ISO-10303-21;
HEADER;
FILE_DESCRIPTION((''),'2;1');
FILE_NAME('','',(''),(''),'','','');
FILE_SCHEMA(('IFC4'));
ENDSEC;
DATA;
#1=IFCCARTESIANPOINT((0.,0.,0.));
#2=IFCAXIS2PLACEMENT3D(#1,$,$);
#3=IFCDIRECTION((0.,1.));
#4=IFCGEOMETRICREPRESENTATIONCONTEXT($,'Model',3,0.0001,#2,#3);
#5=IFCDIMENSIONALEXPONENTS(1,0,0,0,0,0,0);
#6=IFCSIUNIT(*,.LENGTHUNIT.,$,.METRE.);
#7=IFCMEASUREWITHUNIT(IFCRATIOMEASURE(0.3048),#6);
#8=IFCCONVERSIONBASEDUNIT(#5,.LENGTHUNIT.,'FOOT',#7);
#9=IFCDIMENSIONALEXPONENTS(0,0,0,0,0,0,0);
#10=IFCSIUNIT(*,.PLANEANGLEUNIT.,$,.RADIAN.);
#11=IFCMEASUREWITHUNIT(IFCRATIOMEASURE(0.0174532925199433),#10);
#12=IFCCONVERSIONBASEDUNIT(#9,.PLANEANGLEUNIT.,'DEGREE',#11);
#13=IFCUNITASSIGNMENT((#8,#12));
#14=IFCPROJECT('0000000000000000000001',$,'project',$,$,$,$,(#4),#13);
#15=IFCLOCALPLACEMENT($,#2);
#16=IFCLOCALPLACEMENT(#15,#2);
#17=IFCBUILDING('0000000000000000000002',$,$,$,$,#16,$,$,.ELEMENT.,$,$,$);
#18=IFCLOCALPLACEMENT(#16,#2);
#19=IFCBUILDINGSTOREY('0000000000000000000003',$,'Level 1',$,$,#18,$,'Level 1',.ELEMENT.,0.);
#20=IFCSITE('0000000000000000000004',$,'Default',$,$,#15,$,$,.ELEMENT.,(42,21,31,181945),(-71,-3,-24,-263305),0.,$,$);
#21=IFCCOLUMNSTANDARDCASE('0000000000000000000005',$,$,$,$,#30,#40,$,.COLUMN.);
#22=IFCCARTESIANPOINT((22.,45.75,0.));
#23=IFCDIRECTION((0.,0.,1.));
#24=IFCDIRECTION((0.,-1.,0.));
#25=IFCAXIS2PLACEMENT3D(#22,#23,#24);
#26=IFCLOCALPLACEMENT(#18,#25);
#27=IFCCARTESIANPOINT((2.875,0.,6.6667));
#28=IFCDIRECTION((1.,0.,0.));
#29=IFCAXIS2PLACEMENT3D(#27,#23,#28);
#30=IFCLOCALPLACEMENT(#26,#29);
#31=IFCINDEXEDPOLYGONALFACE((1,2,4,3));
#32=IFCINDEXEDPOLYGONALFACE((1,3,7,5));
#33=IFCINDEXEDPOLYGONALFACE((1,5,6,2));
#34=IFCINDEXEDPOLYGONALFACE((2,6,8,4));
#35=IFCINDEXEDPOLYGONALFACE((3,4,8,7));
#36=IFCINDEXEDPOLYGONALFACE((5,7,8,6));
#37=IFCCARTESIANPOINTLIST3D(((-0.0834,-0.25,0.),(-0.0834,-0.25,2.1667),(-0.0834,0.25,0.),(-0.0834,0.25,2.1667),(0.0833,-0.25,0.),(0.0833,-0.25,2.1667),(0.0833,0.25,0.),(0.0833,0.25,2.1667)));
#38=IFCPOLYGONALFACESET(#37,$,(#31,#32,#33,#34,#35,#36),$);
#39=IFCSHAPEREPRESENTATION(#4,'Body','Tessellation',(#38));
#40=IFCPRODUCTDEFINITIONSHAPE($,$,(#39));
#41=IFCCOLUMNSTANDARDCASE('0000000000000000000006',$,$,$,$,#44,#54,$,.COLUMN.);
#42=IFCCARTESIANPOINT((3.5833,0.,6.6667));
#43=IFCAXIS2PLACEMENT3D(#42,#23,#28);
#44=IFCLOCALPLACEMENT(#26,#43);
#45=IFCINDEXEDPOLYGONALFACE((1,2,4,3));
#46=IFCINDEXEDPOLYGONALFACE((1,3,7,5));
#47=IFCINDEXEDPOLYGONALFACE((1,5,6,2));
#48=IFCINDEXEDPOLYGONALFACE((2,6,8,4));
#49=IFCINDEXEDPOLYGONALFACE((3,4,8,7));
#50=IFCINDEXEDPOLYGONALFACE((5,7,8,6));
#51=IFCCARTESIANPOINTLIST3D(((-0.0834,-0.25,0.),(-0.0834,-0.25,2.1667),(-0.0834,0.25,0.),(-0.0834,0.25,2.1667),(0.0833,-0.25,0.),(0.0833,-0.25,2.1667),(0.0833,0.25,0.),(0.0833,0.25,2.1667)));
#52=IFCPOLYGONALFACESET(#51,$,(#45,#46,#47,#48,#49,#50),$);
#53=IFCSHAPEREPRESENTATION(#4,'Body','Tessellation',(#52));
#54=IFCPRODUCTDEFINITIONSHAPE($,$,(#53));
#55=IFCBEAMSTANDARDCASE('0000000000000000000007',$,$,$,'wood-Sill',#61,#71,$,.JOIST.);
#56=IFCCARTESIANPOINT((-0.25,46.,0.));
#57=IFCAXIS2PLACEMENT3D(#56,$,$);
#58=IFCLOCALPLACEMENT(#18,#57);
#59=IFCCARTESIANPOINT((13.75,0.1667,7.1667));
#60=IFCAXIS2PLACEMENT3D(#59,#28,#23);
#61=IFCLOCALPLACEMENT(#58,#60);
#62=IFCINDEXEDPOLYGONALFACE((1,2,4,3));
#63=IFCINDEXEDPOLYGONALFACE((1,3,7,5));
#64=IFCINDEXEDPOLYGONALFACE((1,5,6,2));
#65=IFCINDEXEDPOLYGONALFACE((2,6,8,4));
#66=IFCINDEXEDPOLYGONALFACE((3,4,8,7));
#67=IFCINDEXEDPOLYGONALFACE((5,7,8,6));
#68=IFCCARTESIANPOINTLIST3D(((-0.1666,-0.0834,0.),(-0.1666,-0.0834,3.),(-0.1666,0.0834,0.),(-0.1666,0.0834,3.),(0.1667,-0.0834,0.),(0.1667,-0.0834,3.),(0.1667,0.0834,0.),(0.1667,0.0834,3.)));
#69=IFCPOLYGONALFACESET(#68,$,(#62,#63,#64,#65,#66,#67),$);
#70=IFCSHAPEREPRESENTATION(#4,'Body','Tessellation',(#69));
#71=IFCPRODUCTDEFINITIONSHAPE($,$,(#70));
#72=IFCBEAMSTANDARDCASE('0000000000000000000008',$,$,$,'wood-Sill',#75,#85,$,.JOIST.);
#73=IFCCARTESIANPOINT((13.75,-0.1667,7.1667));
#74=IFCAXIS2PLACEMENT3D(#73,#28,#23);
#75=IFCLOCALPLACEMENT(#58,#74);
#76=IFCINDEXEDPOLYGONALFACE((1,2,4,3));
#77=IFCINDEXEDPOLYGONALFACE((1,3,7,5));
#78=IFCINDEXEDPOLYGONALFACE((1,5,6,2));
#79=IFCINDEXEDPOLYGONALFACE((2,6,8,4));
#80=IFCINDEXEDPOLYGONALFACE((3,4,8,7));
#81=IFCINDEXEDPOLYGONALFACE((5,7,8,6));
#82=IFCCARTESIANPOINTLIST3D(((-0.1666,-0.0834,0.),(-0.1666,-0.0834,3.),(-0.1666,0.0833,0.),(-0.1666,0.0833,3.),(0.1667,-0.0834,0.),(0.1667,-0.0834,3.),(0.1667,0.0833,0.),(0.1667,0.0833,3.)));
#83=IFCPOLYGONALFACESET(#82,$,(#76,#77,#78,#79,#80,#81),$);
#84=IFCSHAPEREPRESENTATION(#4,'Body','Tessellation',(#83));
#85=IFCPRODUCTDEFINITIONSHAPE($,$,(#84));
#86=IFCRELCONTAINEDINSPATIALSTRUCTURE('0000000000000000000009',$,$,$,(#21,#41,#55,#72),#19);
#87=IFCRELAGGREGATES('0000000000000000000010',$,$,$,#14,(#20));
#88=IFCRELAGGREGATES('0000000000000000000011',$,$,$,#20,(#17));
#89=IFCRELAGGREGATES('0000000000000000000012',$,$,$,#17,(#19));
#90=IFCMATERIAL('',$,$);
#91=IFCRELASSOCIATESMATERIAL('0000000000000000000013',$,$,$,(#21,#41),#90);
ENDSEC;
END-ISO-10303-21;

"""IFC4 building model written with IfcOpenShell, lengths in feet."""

from ifc_helpers import new_model, entity, si_unit, converted_unit, direction, frame, origin, origin_with_axes, place, context, project, spatial, rectangle, extrude, material, element, save


model = new_model("IFC4")

# Units and contexts
model_context = context("Model", 3, precision=0.0001, world=origin(), true_north=direction((0.0, 1.0)))
ifc_project = project(units=[converted_unit("LENGTHUNIT", "FOOT", entity("IfcRatioMeasure", 0.3048), si_unit("LENGTHUNIT", "METRE"), dimensions=[1, 0, 0, 0, 0, 0, 0]), converted_unit("PLANEANGLEUNIT", "DEGREE", entity("IfcRatioMeasure", 0.0174532925199433), si_unit("PLANEANGLEUNIT", "RADIAN"), dimensions=[0, 0, 0, 0, 0, 0, 0])], contexts=[model_context])

# Site, building, storey
site_placement = place(None, origin())
site = spatial("IfcSite", under=ifc_project, at=site_placement, Name="Default", CompositionType="ELEMENT", RefLatitude=(42, 21, 31, 181945), RefLongitude=(-71, -3, -24, -263305), RefElevation=0.0)
building_placement = place(site_placement, origin())
building = spatial("IfcBuilding", under=site, at=building_placement, CompositionType="ELEMENT")
storey_placement = place(building_placement, origin())
storey = spatial("IfcBuildingStorey", under=building, at=storey_placement, Name="Level 1", LongName="Level 1", CompositionType="ELEMENT", Elevation=0.0)

# Columns
placement_1 = place(storey_placement, frame((-0.25, 46.0, 0.0)))
ifc_material_1 = material(Name="")
placement_2 = place(storey_placement, frame((22.0, 45.75, 0.0), z_axis=(0.0, 0.0, 1.0), x_axis=(0.0, -1.0, 0.0)))
for number, where, z_axis, x_axis in (
    (1, (2.875, 0.0, 6.6667), (0.0, 0.0, 1.0), (1.0, 0.0, 0.0)),
    (2, (3.5833, 0.0, 6.6667), (0.0, 0.0, 1.0), (1.0, 0.0, 0.0)),
):
    element("IfcColumnStandardCase", number, at=place(placement_2, frame(where, z_axis=z_axis, x_axis=x_axis)), inside=storey, material=ifc_material_1, PredefinedType="COLUMN", context=model_context, shape_type="SweptSolid", body=[
        extrude(rectangle(XDim=0.1667, YDim=0.5), origin(), (0.0, 0.0, 1.0), 2.1667),
    ])

# Beams
for number, where, z_axis, x_axis in (
    (3, (13.75, 0.1667, 7.1667), (1.0, 0.0, 0.0), (0.0, 0.0, 1.0)),
    (4, (13.75, -0.1667, 7.1667), (1.0, 0.0, 0.0), (0.0, 0.0, 1.0)),
):
    element("IfcBeamStandardCase", number, at=place(placement_1, frame(where, z_axis=z_axis, x_axis=x_axis)), inside=storey, ObjectType="wood-Sill", PredefinedType="JOIST", context=model_context, shape_type="SweptSolid", body=[
        extrude(rectangle(XDim=0.3333, YDim=0.1667), origin_with_axes(), (0.0, 0.0, 1.0), 3.0),
    ])

save(model, "model.ifc")
